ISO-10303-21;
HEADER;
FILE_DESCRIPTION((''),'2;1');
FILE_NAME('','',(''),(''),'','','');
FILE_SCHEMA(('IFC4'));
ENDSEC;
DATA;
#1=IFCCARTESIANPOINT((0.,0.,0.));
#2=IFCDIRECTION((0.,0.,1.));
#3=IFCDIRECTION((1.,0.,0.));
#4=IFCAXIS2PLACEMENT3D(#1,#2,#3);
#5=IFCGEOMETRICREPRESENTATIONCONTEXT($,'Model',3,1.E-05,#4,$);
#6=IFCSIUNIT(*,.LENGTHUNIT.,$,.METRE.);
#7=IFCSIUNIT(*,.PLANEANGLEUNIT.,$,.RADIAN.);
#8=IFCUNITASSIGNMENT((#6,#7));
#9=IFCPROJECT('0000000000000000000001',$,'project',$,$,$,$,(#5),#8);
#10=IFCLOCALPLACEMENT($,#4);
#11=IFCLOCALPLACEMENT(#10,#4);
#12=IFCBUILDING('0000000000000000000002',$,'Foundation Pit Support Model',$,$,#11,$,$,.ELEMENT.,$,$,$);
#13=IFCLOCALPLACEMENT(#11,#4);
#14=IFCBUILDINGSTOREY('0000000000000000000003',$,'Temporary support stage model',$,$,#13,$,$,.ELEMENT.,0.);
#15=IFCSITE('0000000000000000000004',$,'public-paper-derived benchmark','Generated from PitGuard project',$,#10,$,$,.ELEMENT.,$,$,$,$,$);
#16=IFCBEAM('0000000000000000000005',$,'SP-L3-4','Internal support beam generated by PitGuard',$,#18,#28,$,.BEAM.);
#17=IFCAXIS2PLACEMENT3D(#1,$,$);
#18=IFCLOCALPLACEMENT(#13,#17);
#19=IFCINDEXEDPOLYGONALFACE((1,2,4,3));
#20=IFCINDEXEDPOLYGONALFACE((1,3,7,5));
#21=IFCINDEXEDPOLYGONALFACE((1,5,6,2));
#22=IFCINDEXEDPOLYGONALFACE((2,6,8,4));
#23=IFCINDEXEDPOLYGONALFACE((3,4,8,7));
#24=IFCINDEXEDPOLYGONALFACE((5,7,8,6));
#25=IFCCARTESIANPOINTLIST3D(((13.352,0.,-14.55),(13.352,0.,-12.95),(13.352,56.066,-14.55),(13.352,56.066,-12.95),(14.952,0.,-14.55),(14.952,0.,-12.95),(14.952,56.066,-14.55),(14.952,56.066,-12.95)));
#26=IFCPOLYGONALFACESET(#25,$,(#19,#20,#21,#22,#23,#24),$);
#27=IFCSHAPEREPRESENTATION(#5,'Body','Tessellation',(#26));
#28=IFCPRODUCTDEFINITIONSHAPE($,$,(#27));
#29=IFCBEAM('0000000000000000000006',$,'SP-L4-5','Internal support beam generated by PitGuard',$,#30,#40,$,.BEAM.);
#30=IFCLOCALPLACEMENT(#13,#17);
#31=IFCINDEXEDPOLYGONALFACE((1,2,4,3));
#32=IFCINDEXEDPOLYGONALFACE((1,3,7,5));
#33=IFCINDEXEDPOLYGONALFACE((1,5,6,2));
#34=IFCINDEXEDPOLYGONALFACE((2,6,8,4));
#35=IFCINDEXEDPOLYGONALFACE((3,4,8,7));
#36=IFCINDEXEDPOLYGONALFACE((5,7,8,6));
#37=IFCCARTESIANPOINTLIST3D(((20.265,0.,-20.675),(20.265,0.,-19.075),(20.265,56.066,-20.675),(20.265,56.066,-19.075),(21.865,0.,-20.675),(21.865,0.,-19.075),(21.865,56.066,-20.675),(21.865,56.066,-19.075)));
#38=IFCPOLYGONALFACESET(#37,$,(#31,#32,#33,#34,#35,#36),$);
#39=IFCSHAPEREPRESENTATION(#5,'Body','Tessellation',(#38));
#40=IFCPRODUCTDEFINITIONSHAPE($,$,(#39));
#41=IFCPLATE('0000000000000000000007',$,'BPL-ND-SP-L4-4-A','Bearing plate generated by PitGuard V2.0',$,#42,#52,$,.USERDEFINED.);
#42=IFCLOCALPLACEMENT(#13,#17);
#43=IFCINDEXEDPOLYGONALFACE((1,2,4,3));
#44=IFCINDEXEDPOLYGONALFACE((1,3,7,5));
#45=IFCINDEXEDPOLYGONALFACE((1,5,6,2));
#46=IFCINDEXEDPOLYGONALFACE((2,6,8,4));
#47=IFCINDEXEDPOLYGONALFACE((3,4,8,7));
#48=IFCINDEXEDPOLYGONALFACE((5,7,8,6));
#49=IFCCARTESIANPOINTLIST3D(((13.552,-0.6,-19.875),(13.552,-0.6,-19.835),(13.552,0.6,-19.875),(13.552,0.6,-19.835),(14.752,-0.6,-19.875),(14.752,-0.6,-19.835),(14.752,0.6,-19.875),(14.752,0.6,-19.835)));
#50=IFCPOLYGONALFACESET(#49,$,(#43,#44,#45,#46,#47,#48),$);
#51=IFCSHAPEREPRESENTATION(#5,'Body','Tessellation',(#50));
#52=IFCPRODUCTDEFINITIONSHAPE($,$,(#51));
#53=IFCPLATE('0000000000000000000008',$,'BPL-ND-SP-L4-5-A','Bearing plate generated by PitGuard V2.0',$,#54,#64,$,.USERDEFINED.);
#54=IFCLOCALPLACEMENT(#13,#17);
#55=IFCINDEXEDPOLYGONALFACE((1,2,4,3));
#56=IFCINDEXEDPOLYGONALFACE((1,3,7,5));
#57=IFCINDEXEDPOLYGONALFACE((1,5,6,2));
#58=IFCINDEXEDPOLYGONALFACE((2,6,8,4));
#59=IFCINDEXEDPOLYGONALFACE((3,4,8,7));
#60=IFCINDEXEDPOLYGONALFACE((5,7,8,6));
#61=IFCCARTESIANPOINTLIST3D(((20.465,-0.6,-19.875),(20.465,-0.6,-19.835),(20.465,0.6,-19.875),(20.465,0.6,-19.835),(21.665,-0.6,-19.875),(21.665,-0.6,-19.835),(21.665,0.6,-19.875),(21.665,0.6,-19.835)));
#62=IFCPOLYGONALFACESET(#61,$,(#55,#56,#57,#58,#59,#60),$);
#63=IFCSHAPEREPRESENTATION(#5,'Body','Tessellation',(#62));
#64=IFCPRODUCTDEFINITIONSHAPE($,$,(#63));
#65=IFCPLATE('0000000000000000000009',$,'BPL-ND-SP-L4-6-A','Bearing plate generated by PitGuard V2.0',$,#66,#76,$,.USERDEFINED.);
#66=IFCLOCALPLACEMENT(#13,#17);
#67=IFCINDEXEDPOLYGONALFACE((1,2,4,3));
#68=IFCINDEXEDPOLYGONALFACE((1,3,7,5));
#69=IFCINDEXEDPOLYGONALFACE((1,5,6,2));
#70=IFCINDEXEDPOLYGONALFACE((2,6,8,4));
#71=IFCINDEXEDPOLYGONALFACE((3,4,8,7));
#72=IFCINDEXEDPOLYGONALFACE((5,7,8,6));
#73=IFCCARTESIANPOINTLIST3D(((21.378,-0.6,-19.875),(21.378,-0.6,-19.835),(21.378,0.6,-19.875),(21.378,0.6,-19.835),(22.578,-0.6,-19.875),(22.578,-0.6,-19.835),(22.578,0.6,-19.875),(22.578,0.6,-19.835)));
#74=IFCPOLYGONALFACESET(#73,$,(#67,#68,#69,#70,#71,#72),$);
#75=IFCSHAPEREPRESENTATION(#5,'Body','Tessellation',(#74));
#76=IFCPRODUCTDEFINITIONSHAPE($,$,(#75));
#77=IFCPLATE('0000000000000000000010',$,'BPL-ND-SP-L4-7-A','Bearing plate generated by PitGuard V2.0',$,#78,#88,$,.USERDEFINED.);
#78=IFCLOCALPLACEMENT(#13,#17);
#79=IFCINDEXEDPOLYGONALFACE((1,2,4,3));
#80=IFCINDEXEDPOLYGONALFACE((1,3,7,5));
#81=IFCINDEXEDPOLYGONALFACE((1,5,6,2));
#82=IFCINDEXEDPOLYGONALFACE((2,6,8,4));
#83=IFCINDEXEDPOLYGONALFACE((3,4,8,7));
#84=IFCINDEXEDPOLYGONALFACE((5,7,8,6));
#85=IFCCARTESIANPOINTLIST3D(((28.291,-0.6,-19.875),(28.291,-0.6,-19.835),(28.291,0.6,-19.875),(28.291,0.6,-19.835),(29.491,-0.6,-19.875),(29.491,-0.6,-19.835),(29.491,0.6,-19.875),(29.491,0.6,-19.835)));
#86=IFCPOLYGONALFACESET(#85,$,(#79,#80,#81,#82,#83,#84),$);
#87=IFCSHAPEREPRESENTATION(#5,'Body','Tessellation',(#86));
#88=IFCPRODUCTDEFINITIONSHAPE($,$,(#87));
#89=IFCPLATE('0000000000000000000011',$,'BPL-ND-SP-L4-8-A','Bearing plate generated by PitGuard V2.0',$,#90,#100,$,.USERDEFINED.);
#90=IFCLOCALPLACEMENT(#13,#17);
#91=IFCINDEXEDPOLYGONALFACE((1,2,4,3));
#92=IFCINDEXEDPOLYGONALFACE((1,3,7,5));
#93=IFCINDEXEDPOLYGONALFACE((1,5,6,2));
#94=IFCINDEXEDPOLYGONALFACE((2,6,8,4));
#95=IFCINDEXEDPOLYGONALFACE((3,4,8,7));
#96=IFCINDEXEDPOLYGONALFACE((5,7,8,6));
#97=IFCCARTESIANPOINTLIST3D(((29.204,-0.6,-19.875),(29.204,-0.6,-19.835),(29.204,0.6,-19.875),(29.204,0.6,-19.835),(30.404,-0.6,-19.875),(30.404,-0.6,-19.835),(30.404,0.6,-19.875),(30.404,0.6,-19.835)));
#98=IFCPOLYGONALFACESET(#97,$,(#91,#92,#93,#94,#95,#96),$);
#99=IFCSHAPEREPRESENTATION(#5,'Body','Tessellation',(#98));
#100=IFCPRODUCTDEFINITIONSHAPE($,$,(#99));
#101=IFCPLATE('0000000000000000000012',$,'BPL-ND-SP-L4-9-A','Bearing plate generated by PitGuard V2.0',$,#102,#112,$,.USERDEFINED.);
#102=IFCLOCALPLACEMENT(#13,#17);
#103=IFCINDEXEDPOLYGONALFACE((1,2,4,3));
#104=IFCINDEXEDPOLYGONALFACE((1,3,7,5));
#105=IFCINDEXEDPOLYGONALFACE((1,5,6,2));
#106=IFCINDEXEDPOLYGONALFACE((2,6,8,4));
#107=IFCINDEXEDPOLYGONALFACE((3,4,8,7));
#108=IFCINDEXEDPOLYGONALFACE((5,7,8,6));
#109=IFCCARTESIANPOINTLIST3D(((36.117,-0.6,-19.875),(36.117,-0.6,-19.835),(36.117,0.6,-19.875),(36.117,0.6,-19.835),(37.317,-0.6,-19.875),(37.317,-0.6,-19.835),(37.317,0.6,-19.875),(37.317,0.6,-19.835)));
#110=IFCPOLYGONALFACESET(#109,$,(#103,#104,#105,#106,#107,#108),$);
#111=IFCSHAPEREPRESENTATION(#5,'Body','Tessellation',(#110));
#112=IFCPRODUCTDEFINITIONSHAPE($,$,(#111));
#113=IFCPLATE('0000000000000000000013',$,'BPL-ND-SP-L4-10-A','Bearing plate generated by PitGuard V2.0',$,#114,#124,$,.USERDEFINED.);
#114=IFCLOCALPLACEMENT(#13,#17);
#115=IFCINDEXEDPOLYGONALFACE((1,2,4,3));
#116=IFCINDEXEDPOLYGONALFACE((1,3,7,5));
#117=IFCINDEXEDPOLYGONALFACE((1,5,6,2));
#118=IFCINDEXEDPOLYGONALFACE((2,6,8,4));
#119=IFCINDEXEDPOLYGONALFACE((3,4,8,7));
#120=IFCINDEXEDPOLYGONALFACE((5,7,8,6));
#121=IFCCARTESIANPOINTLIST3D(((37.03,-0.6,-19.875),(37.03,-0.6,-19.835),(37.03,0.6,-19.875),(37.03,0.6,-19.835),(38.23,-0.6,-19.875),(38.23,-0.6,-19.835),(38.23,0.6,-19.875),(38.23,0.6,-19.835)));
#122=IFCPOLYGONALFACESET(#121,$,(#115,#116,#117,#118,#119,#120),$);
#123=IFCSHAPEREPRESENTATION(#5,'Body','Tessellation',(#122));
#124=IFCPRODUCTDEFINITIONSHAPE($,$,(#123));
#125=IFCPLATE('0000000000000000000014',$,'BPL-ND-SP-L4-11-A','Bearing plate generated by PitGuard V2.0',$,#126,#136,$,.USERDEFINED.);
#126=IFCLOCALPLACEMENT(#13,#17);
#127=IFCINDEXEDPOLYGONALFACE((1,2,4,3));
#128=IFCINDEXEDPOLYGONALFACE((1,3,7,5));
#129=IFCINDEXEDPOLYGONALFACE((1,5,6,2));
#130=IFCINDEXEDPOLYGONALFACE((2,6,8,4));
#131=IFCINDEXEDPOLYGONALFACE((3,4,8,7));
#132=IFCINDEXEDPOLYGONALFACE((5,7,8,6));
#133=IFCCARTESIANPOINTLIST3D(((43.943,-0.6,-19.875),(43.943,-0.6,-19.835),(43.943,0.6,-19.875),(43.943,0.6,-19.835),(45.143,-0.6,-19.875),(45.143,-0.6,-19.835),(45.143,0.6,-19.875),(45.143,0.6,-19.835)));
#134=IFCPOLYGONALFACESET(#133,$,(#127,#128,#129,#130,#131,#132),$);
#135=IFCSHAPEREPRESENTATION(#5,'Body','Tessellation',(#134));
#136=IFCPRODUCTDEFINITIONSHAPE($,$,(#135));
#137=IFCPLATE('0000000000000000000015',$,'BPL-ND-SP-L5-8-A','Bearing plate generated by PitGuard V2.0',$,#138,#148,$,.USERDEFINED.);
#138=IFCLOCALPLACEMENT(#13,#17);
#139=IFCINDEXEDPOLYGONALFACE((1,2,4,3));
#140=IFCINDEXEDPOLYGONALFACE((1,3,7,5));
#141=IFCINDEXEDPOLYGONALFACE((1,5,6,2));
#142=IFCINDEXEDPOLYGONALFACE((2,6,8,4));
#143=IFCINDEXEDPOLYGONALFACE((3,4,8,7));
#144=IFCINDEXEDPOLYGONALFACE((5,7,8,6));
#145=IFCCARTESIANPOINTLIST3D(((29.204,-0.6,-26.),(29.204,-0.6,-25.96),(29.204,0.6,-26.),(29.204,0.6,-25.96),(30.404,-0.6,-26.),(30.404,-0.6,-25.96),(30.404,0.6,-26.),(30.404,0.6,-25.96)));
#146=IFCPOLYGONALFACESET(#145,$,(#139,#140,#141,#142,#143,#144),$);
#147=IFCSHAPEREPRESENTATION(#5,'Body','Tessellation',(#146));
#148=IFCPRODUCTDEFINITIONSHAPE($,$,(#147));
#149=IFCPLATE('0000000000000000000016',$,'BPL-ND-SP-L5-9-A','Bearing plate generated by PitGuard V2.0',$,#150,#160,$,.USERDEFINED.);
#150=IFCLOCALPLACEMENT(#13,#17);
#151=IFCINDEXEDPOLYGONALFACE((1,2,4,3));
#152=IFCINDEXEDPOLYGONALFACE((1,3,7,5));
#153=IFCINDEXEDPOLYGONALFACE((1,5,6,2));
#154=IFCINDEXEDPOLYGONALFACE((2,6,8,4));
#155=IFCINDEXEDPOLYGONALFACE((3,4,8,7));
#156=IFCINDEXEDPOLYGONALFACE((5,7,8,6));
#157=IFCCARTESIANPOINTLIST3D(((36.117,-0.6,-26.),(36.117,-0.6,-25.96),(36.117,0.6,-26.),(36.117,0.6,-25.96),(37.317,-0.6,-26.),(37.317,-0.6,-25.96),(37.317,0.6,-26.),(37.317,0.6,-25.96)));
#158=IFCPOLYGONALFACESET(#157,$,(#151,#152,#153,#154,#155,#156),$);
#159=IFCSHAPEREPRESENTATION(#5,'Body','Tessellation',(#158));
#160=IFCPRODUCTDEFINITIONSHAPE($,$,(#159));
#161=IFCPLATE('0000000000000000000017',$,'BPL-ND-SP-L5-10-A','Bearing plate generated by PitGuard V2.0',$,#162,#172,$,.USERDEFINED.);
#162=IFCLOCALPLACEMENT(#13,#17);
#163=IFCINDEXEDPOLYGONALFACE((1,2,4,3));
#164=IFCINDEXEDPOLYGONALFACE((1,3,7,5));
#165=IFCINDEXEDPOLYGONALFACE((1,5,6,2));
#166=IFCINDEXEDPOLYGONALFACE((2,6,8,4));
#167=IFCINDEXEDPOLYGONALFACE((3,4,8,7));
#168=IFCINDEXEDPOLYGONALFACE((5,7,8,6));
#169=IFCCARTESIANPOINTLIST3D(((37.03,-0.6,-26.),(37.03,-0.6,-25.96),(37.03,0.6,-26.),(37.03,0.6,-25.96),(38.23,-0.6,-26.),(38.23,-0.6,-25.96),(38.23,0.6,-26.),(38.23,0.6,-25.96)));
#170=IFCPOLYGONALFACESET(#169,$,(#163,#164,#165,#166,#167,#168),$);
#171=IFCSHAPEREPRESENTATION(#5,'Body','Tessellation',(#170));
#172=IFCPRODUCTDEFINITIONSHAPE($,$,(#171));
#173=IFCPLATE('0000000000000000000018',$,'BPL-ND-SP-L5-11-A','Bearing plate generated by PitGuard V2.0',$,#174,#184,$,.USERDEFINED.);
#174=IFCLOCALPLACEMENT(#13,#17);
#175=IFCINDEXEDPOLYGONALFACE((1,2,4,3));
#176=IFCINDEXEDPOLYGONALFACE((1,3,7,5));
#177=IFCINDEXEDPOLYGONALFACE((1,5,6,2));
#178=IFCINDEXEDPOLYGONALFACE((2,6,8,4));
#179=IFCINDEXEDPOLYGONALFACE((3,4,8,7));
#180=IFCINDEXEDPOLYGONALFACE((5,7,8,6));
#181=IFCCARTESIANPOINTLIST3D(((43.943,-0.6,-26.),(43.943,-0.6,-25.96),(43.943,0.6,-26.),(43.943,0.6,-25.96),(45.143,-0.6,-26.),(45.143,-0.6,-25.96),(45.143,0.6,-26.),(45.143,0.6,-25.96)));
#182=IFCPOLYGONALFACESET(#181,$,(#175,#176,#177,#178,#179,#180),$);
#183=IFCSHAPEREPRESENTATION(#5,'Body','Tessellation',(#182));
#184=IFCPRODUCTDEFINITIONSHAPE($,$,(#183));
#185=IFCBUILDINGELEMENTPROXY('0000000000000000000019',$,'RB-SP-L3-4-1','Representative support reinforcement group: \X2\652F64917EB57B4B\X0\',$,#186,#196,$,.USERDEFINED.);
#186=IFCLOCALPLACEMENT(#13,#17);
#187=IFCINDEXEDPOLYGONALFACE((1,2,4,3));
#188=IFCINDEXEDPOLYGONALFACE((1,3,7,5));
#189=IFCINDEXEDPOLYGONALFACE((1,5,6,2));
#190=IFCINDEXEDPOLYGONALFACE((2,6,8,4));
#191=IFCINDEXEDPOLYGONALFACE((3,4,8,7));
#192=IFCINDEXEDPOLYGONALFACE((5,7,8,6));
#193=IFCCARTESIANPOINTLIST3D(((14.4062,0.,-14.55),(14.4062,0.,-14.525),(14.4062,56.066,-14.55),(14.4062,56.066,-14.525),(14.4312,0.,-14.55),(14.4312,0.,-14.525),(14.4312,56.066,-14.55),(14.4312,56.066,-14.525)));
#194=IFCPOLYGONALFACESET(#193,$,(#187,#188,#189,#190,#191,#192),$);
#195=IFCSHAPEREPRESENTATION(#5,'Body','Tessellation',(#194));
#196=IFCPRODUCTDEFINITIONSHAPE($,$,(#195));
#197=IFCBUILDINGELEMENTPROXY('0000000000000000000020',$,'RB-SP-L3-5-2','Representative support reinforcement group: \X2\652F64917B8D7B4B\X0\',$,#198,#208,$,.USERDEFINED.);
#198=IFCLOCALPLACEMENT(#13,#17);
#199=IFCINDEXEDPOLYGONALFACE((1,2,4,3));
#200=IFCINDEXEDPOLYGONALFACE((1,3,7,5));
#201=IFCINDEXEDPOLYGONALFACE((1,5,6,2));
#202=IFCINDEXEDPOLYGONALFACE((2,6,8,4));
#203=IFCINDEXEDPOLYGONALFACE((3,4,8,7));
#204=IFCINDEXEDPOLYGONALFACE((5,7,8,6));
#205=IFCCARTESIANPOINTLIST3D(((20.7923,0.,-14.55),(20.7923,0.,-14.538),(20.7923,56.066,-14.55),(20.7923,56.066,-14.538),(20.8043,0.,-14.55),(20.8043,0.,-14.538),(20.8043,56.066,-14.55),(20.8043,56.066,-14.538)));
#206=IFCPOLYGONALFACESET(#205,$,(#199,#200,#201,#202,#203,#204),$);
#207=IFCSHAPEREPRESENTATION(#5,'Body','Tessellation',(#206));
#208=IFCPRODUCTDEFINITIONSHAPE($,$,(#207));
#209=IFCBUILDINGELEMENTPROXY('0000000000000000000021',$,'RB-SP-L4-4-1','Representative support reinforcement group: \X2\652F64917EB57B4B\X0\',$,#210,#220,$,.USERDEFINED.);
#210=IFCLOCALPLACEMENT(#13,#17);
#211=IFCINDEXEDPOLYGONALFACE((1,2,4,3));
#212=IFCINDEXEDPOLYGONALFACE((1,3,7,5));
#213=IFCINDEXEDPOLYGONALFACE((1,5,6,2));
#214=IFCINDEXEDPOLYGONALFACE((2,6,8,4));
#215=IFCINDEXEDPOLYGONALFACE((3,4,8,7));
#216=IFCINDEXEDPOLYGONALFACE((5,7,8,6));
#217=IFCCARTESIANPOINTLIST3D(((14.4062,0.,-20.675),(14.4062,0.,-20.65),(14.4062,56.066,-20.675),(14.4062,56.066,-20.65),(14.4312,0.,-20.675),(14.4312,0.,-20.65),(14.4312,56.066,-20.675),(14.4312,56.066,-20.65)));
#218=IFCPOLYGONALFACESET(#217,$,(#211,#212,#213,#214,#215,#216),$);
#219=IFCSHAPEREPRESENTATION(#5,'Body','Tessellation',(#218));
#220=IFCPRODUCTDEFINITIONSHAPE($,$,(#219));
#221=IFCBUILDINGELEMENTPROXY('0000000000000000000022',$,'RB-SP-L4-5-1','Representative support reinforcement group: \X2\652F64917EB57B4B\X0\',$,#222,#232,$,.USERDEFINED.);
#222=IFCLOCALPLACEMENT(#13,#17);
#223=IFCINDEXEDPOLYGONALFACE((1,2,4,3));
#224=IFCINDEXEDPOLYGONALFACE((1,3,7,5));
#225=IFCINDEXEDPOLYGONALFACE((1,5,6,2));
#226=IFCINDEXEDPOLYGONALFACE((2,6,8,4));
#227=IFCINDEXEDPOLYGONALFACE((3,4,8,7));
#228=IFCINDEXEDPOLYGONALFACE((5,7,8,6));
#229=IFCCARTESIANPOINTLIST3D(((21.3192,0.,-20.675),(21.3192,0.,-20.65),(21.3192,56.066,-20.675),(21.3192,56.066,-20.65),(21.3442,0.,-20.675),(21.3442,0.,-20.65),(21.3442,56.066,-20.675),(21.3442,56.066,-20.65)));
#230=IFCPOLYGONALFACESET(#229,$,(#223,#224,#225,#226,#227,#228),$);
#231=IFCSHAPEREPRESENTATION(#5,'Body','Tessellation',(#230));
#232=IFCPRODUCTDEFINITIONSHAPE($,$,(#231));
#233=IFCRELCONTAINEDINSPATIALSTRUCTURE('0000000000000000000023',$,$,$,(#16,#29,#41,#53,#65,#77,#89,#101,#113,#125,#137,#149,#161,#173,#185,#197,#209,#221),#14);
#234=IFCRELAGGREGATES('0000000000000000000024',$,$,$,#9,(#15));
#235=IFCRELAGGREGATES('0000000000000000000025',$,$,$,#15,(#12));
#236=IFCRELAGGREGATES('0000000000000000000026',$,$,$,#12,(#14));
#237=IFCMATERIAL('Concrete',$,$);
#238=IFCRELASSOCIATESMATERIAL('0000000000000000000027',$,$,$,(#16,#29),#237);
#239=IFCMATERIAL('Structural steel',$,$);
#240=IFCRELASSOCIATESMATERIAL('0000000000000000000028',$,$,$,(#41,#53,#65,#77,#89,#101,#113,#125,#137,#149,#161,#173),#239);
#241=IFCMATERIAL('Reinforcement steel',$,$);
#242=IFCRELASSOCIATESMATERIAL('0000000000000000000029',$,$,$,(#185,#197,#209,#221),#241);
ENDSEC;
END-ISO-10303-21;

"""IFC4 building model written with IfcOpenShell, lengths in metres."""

from ifc_helpers import new_model, si_unit, frame, origin_with_axes, origin_2d, place, context, project, spatial, rectangle, extrude, material, element, save


model = new_model("IFC4")

# Units and contexts
model_context = context("Model", 3, precision=1e-05, world=origin_with_axes())
ifc_project = project(units=[si_unit("LENGTHUNIT", "METRE"), si_unit("PLANEANGLEUNIT", "RADIAN")], contexts=[model_context])

# Site, building, storey
site_placement = place(None, origin_with_axes())
site = spatial("IfcSite", under=ifc_project, at=site_placement, Name="public-paper-derived benchmark", Description="Generated from PitGuard project", CompositionType="ELEMENT")
building_placement = place(site_placement, origin_with_axes())
building = spatial("IfcBuilding", under=site, at=building_placement, Name="Foundation Pit Support Model", CompositionType="ELEMENT")
storey_placement = place(building_placement, origin_with_axes())
storey = spatial("IfcBuildingStorey", under=building, at=storey_placement, Name="Temporary support stage model", CompositionType="ELEMENT", Elevation=0.0)

# Beams
ifc_material_1 = material(Name="Concrete")
for number, where, z_axis, x_axis, name in (
    (1, (14.152, 28.033, -14.55), (0.0, 0.0, 1.0), (0.0, 1.0, 0.0), "SP-L3-4"),
    (2, (21.065, 28.033, -20.675), (0.0, 0.0, 1.0), (0.0, 1.0, 0.0), "SP-L4-5"),
):
    element("IfcBeam", number, at=place(storey_placement, frame(where, z_axis=z_axis, x_axis=x_axis)), inside=storey, material=ifc_material_1, Name=name, Description="Internal support beam generated by PitGuard", PredefinedType="BEAM", context=model_context, shape_type="SweptSolid", body=[
        extrude(rectangle(XDim=56.066, YDim=1.6, at=origin_2d()), origin_with_axes(), (0.0, 0.0, 1.0), 1.6),
    ])

# Plates
ifc_material_2 = material(Name="Structural steel")
for number, where, z_axis, x_axis, name in (
    (3, (14.152, 0.0, -19.875), (0.0, 0.0, 1.0), (1.0, 0.0, 0.0), "BPL-ND-SP-L4-4-A"),
    (4, (21.065, 0.0, -19.875), (0.0, 0.0, 1.0), (1.0, 0.0, 0.0), "BPL-ND-SP-L4-5-A"),
    (5, (21.978, 0.0, -19.875), (0.0, 0.0, 1.0), (1.0, 0.0, 0.0), "BPL-ND-SP-L4-6-A"),
    (6, (28.891, 0.0, -19.875), (0.0, 0.0, 1.0), (1.0, 0.0, 0.0), "BPL-ND-SP-L4-7-A"),
    (7, (29.804, 0.0, -19.875), (0.0, 0.0, 1.0), (1.0, 0.0, 0.0), "BPL-ND-SP-L4-8-A"),
    (8, (36.717, 0.0, -19.875), (0.0, 0.0, 1.0), (1.0, 0.0, 0.0), "BPL-ND-SP-L4-9-A"),
    (9, (37.63, 0.0, -19.875), (0.0, 0.0, 1.0), (1.0, 0.0, 0.0), "BPL-ND-SP-L4-10-A"),
    (10, (44.543, 0.0, -19.875), (0.0, 0.0, 1.0), (1.0, 0.0, 0.0), "BPL-ND-SP-L4-11-A"),
    (11, (29.804, 0.0, -26.0), (0.0, 0.0, 1.0), (1.0, 0.0, 0.0), "BPL-ND-SP-L5-8-A"),
    (12, (36.717, 0.0, -26.0), (0.0, 0.0, 1.0), (1.0, 0.0, 0.0), "BPL-ND-SP-L5-9-A"),
    (13, (37.63, 0.0, -26.0), (0.0, 0.0, 1.0), (1.0, 0.0, 0.0), "BPL-ND-SP-L5-10-A"),
    (14, (44.543, 0.0, -26.0), (0.0, 0.0, 1.0), (1.0, 0.0, 0.0), "BPL-ND-SP-L5-11-A"),
):
    element("IfcPlate", number, at=place(storey_placement, frame(where, z_axis=z_axis, x_axis=x_axis)), inside=storey, material=ifc_material_2, Name=name, Description="Bearing plate generated by PitGuard V2.0", PredefinedType="USERDEFINED", context=model_context, shape_type="SweptSolid", body=[
        extrude(rectangle(XDim=1.2, YDim=1.2, at=origin_2d()), origin_with_axes(), (0.0, 0.0, 1.0), 0.04),
    ])

# Building element proxies
ifc_material_3 = material(Name="Reinforcement steel")
proxy_1_placement = place(storey_placement, frame((14.4187, 28.033, -14.55), z_axis=(0.0, 0.0, 1.0), x_axis=(0.0, 1.0, 0.0)))
element("IfcBuildingElementProxy", 15, at=proxy_1_placement, inside=storey, material=ifc_material_3, Name="RB-SP-L3-4-1", Description="Representative support reinforcement group: 支撑纵筋", PredefinedType="USERDEFINED", context=model_context, shape_type="SweptSolid", body=[
    extrude(rectangle(XDim=56.066, YDim=0.025, at=origin_2d()), origin_with_axes(), (0.0, 0.0, 1.0), 0.025),
])
proxy_2_placement = place(storey_placement, frame((20.7983, 28.033, -14.55), z_axis=(0.0, 0.0, 1.0), x_axis=(0.0, 1.0, 0.0)))
element("IfcBuildingElementProxy", 16, at=proxy_2_placement, inside=storey, material=ifc_material_3, Name="RB-SP-L3-5-2", Description="Representative support reinforcement group: 支撑箍筋", PredefinedType="USERDEFINED", context=model_context, shape_type="SweptSolid", body=[
    extrude(rectangle(XDim=56.066, YDim=0.012, at=origin_2d()), origin_with_axes(), (0.0, 0.0, 1.0), 0.012),
])
for number, where, z_axis, x_axis, name in (
    (17, (14.4187, 28.033, -20.675), (0.0, 0.0, 1.0), (0.0, 1.0, 0.0), "RB-SP-L4-4-1"),
    (18, (21.3317, 28.033, -20.675), (0.0, 0.0, 1.0), (0.0, 1.0, 0.0), "RB-SP-L4-5-1"),
):
    element("IfcBuildingElementProxy", number, at=place(storey_placement, frame(where, z_axis=z_axis, x_axis=x_axis)), inside=storey, material=ifc_material_3, Name=name, Description="Representative support reinforcement group: 支撑纵筋", PredefinedType="USERDEFINED", context=model_context, shape_type="SweptSolid", body=[
        extrude(rectangle(XDim=56.066, YDim=0.025, at=origin_2d()), origin_with_axes(), (0.0, 0.0, 1.0), 0.025),
    ])

save(model, "model.ifc")
